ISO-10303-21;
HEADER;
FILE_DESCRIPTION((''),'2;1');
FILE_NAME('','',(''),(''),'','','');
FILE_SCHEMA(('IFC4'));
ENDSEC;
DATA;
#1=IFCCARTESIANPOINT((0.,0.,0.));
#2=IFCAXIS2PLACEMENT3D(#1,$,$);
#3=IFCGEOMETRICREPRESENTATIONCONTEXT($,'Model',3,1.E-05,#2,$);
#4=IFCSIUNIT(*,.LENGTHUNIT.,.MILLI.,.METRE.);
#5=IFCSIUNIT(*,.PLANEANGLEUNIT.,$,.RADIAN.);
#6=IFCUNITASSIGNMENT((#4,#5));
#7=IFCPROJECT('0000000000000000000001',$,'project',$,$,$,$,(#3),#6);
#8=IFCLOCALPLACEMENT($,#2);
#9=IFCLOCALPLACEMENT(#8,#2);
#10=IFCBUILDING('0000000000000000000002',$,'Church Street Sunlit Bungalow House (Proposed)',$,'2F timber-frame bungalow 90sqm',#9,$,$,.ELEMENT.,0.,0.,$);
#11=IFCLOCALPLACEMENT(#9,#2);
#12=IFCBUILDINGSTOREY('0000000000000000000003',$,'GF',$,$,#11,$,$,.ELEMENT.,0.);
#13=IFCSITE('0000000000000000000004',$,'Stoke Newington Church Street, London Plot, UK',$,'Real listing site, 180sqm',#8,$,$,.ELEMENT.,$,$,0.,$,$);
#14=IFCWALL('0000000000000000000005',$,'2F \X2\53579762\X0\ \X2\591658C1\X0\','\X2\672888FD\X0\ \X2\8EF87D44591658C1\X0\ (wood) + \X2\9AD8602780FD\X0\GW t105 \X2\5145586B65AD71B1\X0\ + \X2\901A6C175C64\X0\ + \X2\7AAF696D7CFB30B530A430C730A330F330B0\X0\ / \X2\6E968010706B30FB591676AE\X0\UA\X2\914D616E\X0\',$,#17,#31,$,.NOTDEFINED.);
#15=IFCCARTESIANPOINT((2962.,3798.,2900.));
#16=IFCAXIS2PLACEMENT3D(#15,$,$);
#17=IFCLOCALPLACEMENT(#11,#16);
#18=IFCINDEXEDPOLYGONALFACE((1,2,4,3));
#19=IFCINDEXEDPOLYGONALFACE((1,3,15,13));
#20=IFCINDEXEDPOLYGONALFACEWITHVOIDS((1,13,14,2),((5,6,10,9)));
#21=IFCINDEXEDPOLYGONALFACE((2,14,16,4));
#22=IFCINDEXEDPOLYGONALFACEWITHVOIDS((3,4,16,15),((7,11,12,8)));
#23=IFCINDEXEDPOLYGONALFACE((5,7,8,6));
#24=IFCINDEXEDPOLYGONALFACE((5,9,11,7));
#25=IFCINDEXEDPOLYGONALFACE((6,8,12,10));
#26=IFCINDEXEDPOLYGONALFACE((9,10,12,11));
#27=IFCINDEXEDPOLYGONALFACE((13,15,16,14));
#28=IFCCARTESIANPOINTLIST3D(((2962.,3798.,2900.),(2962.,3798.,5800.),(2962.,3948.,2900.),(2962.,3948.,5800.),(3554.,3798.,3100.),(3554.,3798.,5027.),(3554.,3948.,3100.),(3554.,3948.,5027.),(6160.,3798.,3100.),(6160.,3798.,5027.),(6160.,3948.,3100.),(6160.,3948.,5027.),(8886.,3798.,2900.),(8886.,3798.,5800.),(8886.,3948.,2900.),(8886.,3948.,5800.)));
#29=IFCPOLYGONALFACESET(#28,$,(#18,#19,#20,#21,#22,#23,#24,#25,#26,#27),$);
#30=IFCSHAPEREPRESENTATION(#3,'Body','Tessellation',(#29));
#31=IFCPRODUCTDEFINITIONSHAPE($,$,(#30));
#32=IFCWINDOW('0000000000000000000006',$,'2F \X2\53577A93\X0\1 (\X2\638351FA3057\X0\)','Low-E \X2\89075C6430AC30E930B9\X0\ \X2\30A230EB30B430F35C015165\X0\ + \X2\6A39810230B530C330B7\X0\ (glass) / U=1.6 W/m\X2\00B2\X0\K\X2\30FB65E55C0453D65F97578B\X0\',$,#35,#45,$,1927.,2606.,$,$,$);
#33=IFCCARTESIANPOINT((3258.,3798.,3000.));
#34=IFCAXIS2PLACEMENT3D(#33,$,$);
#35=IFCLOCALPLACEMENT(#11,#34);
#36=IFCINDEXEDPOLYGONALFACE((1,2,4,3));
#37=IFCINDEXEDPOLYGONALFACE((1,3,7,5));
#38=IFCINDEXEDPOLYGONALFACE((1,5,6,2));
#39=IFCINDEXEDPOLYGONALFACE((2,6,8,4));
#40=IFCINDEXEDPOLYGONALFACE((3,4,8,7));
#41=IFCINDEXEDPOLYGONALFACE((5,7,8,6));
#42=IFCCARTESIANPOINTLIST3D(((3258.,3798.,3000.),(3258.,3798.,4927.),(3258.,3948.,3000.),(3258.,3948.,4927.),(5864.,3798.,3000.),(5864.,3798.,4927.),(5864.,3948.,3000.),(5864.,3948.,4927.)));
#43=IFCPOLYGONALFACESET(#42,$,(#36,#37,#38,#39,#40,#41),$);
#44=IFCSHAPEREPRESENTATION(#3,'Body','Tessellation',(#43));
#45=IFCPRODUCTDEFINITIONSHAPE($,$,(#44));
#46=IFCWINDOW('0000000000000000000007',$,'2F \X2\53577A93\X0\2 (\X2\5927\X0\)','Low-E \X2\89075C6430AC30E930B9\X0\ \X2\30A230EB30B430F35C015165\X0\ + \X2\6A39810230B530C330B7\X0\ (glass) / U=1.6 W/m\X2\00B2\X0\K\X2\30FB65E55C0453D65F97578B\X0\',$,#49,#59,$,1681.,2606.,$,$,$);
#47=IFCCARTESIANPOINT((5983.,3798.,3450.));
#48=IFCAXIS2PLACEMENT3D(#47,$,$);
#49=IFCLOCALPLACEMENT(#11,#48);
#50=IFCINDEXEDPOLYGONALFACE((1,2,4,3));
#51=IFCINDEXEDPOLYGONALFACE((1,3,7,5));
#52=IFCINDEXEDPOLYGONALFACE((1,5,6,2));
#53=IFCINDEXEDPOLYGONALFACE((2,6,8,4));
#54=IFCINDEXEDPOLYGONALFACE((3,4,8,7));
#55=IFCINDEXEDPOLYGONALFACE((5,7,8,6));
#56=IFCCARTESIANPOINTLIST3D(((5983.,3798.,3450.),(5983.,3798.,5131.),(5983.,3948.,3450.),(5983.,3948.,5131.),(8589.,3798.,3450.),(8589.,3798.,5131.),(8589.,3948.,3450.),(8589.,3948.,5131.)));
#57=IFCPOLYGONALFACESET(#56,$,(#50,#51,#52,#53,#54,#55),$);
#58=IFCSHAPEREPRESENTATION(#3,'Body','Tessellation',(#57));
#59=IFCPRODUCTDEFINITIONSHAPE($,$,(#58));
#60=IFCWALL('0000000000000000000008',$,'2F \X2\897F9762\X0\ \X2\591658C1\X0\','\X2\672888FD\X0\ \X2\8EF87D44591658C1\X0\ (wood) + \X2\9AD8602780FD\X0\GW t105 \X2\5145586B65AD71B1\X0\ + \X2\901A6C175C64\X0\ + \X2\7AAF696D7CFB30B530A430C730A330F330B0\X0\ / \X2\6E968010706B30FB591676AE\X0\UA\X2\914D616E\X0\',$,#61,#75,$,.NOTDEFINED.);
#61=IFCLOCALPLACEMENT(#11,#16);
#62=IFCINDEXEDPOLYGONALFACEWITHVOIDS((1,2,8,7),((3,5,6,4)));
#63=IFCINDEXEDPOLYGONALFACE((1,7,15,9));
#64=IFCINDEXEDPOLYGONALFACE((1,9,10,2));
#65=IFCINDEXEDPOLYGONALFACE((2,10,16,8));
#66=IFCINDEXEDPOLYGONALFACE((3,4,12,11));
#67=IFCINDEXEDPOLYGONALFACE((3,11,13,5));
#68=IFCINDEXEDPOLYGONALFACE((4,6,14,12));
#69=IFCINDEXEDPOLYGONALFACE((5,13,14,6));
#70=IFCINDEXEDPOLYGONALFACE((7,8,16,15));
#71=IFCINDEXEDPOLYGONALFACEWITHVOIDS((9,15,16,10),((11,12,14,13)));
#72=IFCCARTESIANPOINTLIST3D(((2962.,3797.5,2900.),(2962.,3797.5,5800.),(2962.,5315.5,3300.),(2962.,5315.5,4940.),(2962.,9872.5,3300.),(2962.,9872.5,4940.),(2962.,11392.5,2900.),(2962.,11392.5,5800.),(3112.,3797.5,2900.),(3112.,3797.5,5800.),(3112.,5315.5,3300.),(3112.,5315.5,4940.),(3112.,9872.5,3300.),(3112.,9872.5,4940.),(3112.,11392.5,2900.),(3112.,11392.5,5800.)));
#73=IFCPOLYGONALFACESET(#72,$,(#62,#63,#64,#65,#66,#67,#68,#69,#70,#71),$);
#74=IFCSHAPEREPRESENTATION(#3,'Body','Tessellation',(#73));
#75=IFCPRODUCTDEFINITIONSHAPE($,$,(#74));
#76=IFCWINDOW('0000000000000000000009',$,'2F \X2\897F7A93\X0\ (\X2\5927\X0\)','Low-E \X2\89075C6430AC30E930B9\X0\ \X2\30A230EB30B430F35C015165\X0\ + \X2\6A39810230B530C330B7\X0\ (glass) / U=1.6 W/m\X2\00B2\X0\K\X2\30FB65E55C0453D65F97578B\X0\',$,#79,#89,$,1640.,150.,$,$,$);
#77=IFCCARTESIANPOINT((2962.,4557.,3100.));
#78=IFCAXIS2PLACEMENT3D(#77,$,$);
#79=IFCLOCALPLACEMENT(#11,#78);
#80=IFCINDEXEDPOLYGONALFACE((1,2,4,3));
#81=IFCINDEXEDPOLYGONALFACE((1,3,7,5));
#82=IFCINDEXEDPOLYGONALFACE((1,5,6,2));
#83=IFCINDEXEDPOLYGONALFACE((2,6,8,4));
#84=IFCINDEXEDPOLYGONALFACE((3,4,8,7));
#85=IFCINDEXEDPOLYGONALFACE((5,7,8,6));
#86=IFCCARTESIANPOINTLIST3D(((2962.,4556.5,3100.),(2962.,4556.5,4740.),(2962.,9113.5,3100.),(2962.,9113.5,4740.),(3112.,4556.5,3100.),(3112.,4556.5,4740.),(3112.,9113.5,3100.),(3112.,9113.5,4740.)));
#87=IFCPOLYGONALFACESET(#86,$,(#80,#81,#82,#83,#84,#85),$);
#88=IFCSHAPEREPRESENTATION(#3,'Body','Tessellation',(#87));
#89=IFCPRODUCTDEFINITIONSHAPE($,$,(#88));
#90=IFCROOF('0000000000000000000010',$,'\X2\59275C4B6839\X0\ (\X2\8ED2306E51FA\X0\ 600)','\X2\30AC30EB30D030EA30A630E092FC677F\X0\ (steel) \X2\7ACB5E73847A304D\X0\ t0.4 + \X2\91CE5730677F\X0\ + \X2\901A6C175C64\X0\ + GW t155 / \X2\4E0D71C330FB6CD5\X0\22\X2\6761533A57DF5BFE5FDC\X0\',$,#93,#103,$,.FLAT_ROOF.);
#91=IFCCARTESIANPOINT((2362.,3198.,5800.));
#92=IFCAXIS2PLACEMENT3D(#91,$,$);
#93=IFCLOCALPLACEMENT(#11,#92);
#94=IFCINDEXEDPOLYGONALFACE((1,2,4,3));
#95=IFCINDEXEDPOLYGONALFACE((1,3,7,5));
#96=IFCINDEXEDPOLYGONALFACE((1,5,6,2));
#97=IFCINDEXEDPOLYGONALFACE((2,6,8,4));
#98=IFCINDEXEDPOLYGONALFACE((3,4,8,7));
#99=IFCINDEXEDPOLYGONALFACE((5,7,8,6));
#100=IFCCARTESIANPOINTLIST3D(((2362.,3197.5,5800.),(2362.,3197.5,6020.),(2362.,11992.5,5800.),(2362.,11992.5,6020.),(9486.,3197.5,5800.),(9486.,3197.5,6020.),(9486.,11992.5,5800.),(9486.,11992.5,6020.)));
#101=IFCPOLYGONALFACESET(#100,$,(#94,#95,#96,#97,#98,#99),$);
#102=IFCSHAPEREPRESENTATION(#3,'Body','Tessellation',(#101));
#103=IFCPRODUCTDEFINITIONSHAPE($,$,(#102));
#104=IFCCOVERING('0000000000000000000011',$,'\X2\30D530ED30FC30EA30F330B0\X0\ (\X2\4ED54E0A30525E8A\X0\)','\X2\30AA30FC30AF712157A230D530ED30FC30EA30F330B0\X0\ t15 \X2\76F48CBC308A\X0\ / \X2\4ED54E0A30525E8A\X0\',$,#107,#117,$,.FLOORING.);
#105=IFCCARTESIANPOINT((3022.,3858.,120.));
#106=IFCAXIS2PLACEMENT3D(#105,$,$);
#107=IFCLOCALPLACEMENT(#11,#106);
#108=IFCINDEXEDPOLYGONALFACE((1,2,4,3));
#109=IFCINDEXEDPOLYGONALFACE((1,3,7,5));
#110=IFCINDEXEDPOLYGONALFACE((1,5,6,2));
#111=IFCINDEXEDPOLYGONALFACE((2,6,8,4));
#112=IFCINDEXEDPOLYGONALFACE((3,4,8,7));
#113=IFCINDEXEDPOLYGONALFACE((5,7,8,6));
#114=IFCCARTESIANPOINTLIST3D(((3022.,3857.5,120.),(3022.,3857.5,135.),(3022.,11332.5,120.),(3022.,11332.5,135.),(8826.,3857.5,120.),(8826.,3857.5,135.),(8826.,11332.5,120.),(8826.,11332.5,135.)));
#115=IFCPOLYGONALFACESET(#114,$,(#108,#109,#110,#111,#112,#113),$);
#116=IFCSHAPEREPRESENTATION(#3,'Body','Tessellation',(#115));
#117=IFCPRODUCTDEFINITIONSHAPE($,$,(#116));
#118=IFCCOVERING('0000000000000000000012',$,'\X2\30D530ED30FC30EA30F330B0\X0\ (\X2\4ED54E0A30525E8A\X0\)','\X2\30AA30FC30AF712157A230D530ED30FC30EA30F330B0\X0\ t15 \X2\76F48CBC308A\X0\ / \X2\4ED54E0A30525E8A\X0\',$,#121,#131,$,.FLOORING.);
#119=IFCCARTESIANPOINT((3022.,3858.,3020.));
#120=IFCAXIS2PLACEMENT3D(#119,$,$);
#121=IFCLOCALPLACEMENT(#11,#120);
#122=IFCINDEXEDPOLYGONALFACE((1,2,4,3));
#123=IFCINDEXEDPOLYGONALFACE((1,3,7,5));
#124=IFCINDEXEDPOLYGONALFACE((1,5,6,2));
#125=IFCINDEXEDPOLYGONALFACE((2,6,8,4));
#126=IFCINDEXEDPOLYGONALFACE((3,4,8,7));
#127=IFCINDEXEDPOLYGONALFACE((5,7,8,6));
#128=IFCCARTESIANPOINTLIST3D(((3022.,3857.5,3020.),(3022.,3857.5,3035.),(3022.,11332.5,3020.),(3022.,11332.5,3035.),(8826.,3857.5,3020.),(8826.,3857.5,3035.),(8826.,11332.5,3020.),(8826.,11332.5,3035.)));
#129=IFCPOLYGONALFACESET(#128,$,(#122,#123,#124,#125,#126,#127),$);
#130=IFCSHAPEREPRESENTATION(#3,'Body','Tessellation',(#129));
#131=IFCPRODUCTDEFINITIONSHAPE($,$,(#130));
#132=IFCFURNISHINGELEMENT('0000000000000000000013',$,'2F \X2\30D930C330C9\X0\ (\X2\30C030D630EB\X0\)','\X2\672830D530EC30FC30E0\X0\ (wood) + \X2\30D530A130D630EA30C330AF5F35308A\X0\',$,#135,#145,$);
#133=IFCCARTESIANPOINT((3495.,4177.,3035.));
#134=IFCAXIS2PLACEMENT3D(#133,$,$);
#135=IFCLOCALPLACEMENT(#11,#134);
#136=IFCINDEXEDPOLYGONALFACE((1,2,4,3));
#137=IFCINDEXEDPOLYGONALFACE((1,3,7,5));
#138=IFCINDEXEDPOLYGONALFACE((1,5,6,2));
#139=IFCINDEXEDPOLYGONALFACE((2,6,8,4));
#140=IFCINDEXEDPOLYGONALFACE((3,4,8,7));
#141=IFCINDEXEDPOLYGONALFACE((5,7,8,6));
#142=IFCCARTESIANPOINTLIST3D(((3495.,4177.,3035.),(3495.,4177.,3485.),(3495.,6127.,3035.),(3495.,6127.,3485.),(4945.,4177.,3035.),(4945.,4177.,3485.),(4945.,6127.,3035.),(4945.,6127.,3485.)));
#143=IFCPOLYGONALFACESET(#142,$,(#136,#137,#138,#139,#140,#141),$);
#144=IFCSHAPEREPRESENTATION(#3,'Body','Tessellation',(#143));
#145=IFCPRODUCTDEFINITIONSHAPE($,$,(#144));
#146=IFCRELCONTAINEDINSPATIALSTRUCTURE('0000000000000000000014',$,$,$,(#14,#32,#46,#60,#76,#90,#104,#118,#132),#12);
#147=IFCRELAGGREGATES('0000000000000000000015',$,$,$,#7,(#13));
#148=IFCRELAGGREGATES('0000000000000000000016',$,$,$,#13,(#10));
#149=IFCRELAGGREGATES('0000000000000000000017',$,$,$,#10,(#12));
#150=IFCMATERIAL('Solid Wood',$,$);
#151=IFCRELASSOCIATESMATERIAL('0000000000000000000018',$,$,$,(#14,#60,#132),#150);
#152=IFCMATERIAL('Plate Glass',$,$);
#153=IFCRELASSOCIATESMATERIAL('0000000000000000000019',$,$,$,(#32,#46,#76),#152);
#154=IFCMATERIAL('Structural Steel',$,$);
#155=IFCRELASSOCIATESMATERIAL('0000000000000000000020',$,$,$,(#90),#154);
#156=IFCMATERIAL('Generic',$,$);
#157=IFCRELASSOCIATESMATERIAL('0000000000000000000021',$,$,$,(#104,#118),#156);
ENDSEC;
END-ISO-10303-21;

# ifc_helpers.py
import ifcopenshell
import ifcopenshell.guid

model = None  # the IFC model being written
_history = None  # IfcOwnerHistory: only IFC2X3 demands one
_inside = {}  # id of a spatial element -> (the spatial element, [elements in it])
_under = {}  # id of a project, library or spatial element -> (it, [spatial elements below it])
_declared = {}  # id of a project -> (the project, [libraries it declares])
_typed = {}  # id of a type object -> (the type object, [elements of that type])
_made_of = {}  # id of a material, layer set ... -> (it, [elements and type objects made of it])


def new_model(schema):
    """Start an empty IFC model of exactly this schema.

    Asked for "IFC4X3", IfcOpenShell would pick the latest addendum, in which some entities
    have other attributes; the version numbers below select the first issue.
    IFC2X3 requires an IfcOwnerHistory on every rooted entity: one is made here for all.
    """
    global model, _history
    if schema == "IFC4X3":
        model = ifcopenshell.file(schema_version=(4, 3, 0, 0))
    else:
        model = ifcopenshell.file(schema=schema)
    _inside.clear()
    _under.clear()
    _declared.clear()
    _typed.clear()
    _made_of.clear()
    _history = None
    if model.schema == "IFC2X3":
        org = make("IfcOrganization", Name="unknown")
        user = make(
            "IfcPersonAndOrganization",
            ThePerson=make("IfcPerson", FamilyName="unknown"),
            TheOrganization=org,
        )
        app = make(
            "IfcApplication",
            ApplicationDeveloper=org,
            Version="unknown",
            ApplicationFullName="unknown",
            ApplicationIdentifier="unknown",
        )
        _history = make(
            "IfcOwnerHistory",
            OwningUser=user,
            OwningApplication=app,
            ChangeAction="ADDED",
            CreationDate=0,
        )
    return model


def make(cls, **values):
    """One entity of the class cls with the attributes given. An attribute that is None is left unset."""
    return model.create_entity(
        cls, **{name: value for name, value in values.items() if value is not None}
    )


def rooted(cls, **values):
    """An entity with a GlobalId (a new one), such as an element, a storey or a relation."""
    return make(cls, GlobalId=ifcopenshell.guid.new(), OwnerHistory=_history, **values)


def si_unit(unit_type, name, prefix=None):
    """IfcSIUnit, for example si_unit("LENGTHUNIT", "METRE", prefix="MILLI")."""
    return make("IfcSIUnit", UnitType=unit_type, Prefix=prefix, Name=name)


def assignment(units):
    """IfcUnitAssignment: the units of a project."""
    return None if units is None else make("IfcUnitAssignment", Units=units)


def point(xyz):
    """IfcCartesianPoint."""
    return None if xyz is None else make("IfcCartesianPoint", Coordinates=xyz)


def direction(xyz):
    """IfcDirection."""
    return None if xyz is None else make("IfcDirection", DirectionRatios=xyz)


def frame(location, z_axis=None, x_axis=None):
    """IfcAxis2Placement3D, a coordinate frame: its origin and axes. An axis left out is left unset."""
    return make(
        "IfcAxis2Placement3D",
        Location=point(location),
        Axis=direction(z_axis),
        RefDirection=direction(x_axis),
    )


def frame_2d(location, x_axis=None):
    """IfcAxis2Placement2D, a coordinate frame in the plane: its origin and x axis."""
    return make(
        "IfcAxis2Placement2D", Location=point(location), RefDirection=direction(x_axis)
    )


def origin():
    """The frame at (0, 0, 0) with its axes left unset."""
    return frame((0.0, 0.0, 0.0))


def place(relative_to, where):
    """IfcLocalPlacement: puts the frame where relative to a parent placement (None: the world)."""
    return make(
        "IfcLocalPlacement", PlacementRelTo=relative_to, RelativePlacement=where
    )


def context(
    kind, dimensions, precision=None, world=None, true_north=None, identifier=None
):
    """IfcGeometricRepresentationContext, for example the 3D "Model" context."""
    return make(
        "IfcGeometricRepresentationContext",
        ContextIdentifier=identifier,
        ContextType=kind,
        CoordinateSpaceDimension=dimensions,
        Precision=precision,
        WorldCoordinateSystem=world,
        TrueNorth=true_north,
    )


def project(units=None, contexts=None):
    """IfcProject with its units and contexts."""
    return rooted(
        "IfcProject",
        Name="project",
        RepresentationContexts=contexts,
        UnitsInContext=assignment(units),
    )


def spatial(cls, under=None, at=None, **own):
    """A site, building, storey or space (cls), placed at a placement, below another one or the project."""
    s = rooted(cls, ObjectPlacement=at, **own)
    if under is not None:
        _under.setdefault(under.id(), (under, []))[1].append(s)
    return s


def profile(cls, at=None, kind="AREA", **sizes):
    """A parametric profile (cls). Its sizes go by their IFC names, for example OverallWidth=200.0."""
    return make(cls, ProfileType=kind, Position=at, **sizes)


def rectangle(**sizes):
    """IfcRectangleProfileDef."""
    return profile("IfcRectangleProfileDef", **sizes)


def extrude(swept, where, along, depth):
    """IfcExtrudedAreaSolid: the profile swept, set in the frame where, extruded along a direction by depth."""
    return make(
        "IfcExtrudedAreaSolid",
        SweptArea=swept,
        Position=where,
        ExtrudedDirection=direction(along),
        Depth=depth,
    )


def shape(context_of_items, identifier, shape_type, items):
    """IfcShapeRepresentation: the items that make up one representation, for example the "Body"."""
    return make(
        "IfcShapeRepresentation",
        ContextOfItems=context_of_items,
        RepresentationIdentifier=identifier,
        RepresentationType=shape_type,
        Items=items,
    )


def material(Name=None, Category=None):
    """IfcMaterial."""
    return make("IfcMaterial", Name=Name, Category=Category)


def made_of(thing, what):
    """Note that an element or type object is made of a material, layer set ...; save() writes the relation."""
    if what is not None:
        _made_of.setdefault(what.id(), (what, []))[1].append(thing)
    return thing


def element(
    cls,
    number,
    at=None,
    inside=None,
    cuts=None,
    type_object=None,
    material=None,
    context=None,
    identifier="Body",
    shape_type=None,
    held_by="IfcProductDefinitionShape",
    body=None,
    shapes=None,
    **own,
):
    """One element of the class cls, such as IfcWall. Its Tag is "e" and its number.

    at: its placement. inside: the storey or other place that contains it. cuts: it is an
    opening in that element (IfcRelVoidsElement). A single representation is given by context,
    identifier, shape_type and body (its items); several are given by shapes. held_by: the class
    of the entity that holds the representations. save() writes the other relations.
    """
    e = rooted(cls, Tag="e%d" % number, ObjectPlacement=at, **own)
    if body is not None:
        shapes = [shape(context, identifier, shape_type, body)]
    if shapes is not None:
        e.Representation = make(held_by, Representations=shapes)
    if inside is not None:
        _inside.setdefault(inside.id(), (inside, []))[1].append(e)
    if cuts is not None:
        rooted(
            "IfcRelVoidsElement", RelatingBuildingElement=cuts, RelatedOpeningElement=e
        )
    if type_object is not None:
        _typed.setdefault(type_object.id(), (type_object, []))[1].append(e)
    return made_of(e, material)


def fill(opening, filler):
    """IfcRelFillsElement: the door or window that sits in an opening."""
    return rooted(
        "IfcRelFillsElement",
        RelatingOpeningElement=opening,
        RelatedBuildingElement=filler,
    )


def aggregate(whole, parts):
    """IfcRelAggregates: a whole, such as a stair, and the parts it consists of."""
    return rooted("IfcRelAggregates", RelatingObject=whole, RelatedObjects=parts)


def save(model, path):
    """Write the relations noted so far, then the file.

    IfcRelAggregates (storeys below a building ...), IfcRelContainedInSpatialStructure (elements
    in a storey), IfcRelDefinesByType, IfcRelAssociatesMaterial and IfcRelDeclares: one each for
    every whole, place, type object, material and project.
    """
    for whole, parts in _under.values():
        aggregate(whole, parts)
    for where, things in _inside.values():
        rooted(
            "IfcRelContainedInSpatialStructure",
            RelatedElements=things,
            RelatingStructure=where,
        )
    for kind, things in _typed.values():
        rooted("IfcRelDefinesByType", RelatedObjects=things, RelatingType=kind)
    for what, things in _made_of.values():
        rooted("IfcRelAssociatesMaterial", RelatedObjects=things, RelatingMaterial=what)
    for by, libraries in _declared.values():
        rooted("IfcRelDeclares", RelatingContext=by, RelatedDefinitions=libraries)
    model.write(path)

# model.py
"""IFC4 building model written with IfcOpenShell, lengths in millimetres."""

from ifc_helpers import new_model, si_unit, frame, frame_2d, origin, place, context, project, spatial, rectangle, extrude, material, element, fill, save


model = new_model("IFC4")

# Units and contexts
model_context = context("Model", 3, precision=1e-05, world=origin())
ifc_project = project(units=[si_unit("LENGTHUNIT", "METRE", prefix="MILLI"), si_unit("PLANEANGLEUNIT", "RADIAN")], contexts=[model_context])

# Site, building, storey
site_placement = place(None, origin())
site = spatial("IfcSite", under=ifc_project, at=site_placement, Name="Stoke Newington Church Street, London Plot, UK", ObjectType="Real listing site, 180sqm", CompositionType="ELEMENT", RefElevation=0.0)
building_placement = place(site_placement, origin())
building = spatial("IfcBuilding", under=site, at=building_placement, Name="Church Street Sunlit Bungalow House (Proposed)", ObjectType="2F timber-frame bungalow 90sqm", CompositionType="ELEMENT", ElevationOfRefHeight=0.0, ElevationOfTerrain=0.0)
storey_placement = place(building_placement, origin())
storey = spatial("IfcBuildingStorey", under=building, at=storey_placement, Name="GF", CompositionType="ELEMENT", Elevation=0.0)

# Shared definitions
ifc_material_1 = material(Name="Solid Wood")

# Shared definitions
ifc_material_2 = material(Name="Plate Glass")

# Wall, openings, windows
wall_1_placement = place(storey_placement, frame((2962.0, 3798.0, 2900.0)))
wall_1 = element("IfcWall", 1, at=wall_1_placement, inside=storey, material=ifc_material_1, Name="2F 南面 外壁", Description="木製 軸組外壁 (wood) + 高性能GW t105 充填断熱 + 通気層 + 窯業系サイディング / 準耐火・外皮UA配慮", PredefinedType="NOTDEFINED", context=model_context, shape_type="SweptSolid", body=[
    extrude(rectangle(XDim=5924.0, YDim=150.0, at=frame_2d((2962.0, 75.0))), frame((2962.0, 3798.0, 2900.0)), (0.0, 0.0, 1.0), 2900.0),
])
opening_1_placement = place(storey_placement, frame((3258.0, 3798.0, 3000.0)))
opening_1 = element("IfcOpeningElement", 2, at=opening_1_placement, cuts=wall_1, PredefinedType="NOTDEFINED", context=model_context, shape_type="SweptSolid", body=[
    extrude(rectangle(XDim=2606.0, YDim=150.0, at=frame_2d((1303.0, 75.0))), frame((3258.0, 3798.0, 3000.0)), (0.0, 0.0, 1.0), 1927.0),
])
opening_2_placement = place(storey_placement, frame((5983.0, 3798.0, 3450.0)))
opening_2 = element("IfcOpeningElement", 3, at=opening_2_placement, cuts=wall_1, PredefinedType="NOTDEFINED", context=model_context, shape_type="SweptSolid", body=[
    extrude(rectangle(XDim=2606.0, YDim=150.0, at=frame_2d((1303.0, 75.0))), frame((5983.0, 3798.0, 3450.0)), (0.0, 0.0, 1.0), 1681.0),
])
window_1_placement = place(storey_placement, frame((3258.0, 3798.0, 3000.0)))
window_1 = element("IfcWindow", 4, at=window_1_placement, inside=storey, material=ifc_material_2, Name="2F 南窓1 (掃出し)", Description="Low-E 複層ガラス アルゴン封入 + 樹脂サッシ (glass) / U=1.6 W/m²K・日射取得型", OverallHeight=1927.0, OverallWidth=2606.0, context=model_context, shape_type="SweptSolid", body=[
    extrude(rectangle(XDim=2606.0, YDim=150.0, at=frame_2d((1303.0, 75.0))), frame((3258.0, 3798.0, 3000.0)), (0.0, 0.0, 1.0), 1927.0),
])
fill(opening_1, window_1)
window_2_placement = place(storey_placement, frame((5983.0, 3798.0, 3450.0)))
window_2 = element("IfcWindow", 5, at=window_2_placement, inside=storey, material=ifc_material_2, Name="2F 南窓2 (大)", Description="Low-E 複層ガラス アルゴン封入 + 樹脂サッシ (glass) / U=1.6 W/m²K・日射取得型", OverallHeight=1681.0, OverallWidth=2606.0, context=model_context, shape_type="SweptSolid", body=[
    extrude(rectangle(XDim=2606.0, YDim=150.0, at=frame_2d((1303.0, 75.0))), frame((5983.0, 3798.0, 3450.0)), (0.0, 0.0, 1.0), 1681.0),
])
fill(opening_2, window_2)

# Wall, opening, window
wall_2_placement = place(storey_placement, frame((2962.0, 3798.0, 2900.0)))
wall_2 = element("IfcWall", 6, at=wall_2_placement, inside=storey, material=ifc_material_1, Name="2F 西面 外壁", Description="木製 軸組外壁 (wood) + 高性能GW t105 充填断熱 + 通気層 + 窯業系サイディング / 準耐火・外皮UA配慮", PredefinedType="NOTDEFINED", context=model_context, shape_type="SweptSolid", body=[
    extrude(rectangle(XDim=150.0, YDim=7595.0, at=frame_2d((75.0, 3797.0))), frame((2962.0, 3798.0, 2900.0)), (0.0, 0.0, 1.0), 2900.0),
])
opening_3_placement = place(storey_placement, frame((2962.0, 4557.0, 3100.0)))
opening_3 = element("IfcOpeningElement", 7, at=opening_3_placement, cuts=wall_2, PredefinedType="NOTDEFINED", context=model_context, shape_type="SweptSolid", body=[
    extrude(rectangle(XDim=150.0, YDim=4557.0, at=frame_2d((75.0, 2278.0))), frame((2962.0, 4557.0, 3100.0)), (0.0, 0.0, 1.0), 1640.0),
])
window_3_placement = place(storey_placement, frame((2962.0, 4557.0, 3100.0)))
window_3 = element("IfcWindow", 8, at=window_3_placement, inside=storey, material=ifc_material_2, Name="2F 西窓 (大)", Description="Low-E 複層ガラス アルゴン封入 + 樹脂サッシ (glass) / U=1.6 W/m²K・日射取得型", OverallHeight=1640.0, OverallWidth=150.0, context=model_context, shape_type="SweptSolid", body=[
    extrude(rectangle(XDim=150.0, YDim=4557.0, at=frame_2d((75.0, 2278.0))), frame((2962.0, 4557.0, 3100.0)), (0.0, 0.0, 1.0), 1640.0),
])
fill(opening_3, window_3)

# Roof
ifc_material_3 = material(Name="Structural Steel")
roof_placement = place(storey_placement, frame((2362.0, 3198.0, 5800.0)))
element("IfcRoof", 9, at=roof_placement, inside=storey, material=ifc_material_3, Name="大屋根 (軒の出 600)", Description="ガルバリウム鋼板 (steel) 立平葺き t0.4 + 野地板 + 通気層 + GW t155 / 不燃・法22条区域対応", PredefinedType="FLAT_ROOF", context=model_context, shape_type="SweptSolid", body=[
    extrude(rectangle(XDim=7124.0, YDim=8795.0, at=frame_2d((3562.0, 4397.0))), frame((2362.0, 3198.0, 5800.0)), (0.0, 0.0, 1.0), 220.0),
])

# Coverings
ifc_material_4 = material(Name="Generic")
covering_1_placement = place(storey_placement, frame((3022.0, 3858.0, 120.0)))
element("IfcCovering", 10, at=covering_1_placement, inside=storey, material=ifc_material_4, Name="フローリング (仕上げ床)", Description="オーク無垢フローリング t15 直貼り / 仕上げ床", PredefinedType="FLOORING", context=model_context, shape_type="SweptSolid", body=[
    extrude(rectangle(XDim=5804.0, YDim=7475.0, at=frame_2d((2902.0, 3737.0))), frame((3022.0, 3858.0, 120.0)), (0.0, 0.0, 1.0), 15.0),
])
covering_2_placement = place(storey_placement, frame((3022.0, 3858.0, 3020.0)))
element("IfcCovering", 11, at=covering_2_placement, inside=storey, material=ifc_material_4, Name="フローリング (仕上げ床)", Description="オーク無垢フローリング t15 直貼り / 仕上げ床", PredefinedType="FLOORING", context=model_context, shape_type="SweptSolid", body=[
    extrude(rectangle(XDim=5804.0, YDim=7475.0, at=frame_2d((2902.0, 3737.0))), frame((3022.0, 3858.0, 3020.0)), (0.0, 0.0, 1.0), 15.0),
])

# Furnishing element
furnishing_placement = place(storey_placement, frame((3495.0, 4177.0, 3035.0)))
element("IfcFurnishingElement", 12, at=furnishing_placement, inside=storey, material=ifc_material_1, Name="2F ベッド (ダブル)", Description="木フレーム (wood) + ファブリック張り", context=model_context, shape_type="SweptSolid", body=[
    extrude(rectangle(XDim=1450.0, YDim=1950.0, at=frame_2d((725.0, 975.0))), frame((3495.0, 4177.0, 3035.0)), (0.0, 0.0, 1.0), 450.0),
])

save(model, "model.ifc")
